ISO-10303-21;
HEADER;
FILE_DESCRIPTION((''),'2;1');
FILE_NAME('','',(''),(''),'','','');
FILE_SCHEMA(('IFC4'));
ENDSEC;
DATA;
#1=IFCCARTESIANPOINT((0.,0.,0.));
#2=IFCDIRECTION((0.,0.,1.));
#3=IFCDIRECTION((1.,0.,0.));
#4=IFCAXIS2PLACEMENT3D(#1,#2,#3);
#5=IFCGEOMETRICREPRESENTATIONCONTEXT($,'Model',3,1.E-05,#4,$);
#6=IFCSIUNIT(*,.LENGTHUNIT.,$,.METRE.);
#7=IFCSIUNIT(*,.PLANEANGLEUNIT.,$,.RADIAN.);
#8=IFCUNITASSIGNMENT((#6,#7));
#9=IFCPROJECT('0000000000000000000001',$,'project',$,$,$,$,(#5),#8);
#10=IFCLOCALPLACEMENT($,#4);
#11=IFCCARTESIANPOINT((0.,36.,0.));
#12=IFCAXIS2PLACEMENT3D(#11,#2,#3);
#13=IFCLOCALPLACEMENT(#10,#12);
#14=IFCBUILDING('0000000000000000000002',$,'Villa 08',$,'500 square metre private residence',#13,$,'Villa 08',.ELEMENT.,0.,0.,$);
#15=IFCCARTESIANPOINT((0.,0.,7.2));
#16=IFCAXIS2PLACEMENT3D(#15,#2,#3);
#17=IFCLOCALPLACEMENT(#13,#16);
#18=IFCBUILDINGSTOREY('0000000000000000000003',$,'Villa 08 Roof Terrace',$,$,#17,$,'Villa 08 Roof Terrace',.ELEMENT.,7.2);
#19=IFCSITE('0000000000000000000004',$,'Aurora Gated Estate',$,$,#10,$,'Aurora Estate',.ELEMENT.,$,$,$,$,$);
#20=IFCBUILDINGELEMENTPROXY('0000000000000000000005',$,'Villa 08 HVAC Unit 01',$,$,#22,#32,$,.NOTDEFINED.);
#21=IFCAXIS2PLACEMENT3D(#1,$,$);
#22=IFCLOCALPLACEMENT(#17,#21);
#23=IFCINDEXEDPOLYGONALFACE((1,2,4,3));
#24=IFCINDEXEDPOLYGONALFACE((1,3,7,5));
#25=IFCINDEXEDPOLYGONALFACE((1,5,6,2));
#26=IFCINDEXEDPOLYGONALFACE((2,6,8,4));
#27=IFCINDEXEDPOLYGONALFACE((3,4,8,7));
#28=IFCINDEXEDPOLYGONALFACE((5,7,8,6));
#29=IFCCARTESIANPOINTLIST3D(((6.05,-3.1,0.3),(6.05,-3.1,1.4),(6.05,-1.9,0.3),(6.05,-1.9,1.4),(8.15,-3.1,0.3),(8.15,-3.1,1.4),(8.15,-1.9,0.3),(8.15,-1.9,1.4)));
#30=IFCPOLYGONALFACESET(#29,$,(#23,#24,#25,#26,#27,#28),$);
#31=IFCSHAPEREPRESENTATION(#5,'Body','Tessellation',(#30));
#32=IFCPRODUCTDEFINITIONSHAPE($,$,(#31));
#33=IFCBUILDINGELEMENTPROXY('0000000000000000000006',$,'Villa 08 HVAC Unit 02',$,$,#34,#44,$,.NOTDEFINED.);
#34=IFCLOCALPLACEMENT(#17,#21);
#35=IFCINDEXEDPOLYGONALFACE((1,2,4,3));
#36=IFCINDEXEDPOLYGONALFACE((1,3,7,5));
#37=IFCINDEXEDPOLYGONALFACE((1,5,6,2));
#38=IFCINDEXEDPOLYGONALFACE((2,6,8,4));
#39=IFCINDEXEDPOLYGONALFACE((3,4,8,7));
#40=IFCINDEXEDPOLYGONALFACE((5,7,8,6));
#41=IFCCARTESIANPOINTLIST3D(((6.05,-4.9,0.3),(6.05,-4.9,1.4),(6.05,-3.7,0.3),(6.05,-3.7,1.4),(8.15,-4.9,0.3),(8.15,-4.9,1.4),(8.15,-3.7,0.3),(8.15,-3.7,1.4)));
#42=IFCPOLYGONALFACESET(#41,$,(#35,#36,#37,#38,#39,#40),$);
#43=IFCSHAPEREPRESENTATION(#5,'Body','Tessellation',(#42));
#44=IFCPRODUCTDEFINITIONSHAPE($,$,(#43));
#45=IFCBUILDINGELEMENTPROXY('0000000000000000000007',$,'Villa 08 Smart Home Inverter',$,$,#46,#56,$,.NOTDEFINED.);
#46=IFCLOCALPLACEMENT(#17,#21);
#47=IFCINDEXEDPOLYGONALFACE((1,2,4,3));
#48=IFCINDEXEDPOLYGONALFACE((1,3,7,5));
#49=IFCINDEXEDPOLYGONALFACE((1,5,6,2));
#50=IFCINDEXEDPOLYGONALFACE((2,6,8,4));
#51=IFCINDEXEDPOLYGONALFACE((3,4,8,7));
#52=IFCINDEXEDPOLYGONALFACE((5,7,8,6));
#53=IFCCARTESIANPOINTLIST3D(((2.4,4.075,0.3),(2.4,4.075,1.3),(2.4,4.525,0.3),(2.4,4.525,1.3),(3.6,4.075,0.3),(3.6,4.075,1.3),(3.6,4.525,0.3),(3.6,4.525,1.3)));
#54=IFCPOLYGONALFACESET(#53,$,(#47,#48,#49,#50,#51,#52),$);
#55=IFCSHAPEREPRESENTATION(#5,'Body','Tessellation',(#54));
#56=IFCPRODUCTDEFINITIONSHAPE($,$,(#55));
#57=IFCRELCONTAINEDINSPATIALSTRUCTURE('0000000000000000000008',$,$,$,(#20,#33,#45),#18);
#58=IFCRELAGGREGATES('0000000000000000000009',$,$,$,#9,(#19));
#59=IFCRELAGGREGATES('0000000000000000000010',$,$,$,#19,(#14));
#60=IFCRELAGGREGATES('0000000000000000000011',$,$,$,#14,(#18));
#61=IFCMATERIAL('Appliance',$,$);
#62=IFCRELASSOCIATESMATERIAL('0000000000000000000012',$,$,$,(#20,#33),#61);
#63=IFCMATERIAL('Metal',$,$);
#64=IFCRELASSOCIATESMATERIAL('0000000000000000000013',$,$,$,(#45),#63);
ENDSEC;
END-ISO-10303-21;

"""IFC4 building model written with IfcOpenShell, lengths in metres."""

from ifc_helpers import new_model, si_unit, frame, origin_with_axes, origin_2d_with_axis, place, context, project, spatial, rectangle, extrude, material, element, save


model = new_model("IFC4")

# Units and contexts
model_context = context("Model", 3, precision=1e-05, world=origin_with_axes())
ifc_project = project(units=[si_unit("LENGTHUNIT", "METRE"), si_unit("PLANEANGLEUNIT", "RADIAN")], contexts=[model_context])

# Site, building, storey
site_placement = place(None, origin_with_axes())
site = spatial("IfcSite", under=ifc_project, at=site_placement, Name="Aurora Gated Estate", LongName="Aurora Estate", CompositionType="ELEMENT")
building_placement = place(site_placement, frame((0.0, 36.0, 0.0), z_axis=(0.0, 0.0, 1.0), x_axis=(1.0, 0.0, 0.0)))
building = spatial("IfcBuilding", under=site, at=building_placement, Name="Villa 08", ObjectType="500 square metre private residence", LongName="Villa 08", CompositionType="ELEMENT", ElevationOfRefHeight=0.0, ElevationOfTerrain=0.0)
storey_placement = place(building_placement, frame((0.0, 0.0, 7.2), z_axis=(0.0, 0.0, 1.0), x_axis=(1.0, 0.0, 0.0)))
storey = spatial("IfcBuildingStorey", under=building, at=storey_placement, Name="Villa 08 Roof Terrace", LongName="Villa 08 Roof Terrace", CompositionType="ELEMENT", Elevation=7.2)

# Building element proxies
ifc_material_1 = material(Name="Metal")
ifc_material_2 = material(Name="Appliance")
for number, where, z_axis, x_axis, name in (
    (1, (7.1, -2.5, 0.3), (0.0, 0.0, 1.0), (1.0, 0.0, 0.0), "Villa 08 HVAC Unit 01"),
    (2, (7.1, -4.3, 0.3), (0.0, 0.0, 1.0), (1.0, 0.0, 0.0), "Villa 08 HVAC Unit 02"),
):
    element("IfcBuildingElementProxy", number, at=place(storey_placement, frame(where, z_axis=z_axis, x_axis=x_axis)), inside=storey, material=ifc_material_2, Name=name, PredefinedType="NOTDEFINED", context=model_context, shape_type="SweptSolid", body=[
        extrude(rectangle(XDim=2.1, YDim=1.2, at=origin_2d_with_axis()), origin_with_axes(), (0.0, 0.0, 1.0), 1.1),
    ])
proxy_1_placement = place(storey_placement, frame((3.0, 4.3, 0.3), z_axis=(0.0, 0.0, 1.0), x_axis=(1.0, 0.0, 0.0)))
element("IfcBuildingElementProxy", 3, at=proxy_1_placement, inside=storey, material=ifc_material_1, Name="Villa 08 Smart Home Inverter", PredefinedType="NOTDEFINED", context=model_context, shape_type="SweptSolid", body=[
    extrude(rectangle(XDim=1.2, YDim=0.45, at=origin_2d_with_axis()), origin_with_axes(), (0.0, 0.0, 1.0), 1.0),
])

save(model, "model.ifc")
